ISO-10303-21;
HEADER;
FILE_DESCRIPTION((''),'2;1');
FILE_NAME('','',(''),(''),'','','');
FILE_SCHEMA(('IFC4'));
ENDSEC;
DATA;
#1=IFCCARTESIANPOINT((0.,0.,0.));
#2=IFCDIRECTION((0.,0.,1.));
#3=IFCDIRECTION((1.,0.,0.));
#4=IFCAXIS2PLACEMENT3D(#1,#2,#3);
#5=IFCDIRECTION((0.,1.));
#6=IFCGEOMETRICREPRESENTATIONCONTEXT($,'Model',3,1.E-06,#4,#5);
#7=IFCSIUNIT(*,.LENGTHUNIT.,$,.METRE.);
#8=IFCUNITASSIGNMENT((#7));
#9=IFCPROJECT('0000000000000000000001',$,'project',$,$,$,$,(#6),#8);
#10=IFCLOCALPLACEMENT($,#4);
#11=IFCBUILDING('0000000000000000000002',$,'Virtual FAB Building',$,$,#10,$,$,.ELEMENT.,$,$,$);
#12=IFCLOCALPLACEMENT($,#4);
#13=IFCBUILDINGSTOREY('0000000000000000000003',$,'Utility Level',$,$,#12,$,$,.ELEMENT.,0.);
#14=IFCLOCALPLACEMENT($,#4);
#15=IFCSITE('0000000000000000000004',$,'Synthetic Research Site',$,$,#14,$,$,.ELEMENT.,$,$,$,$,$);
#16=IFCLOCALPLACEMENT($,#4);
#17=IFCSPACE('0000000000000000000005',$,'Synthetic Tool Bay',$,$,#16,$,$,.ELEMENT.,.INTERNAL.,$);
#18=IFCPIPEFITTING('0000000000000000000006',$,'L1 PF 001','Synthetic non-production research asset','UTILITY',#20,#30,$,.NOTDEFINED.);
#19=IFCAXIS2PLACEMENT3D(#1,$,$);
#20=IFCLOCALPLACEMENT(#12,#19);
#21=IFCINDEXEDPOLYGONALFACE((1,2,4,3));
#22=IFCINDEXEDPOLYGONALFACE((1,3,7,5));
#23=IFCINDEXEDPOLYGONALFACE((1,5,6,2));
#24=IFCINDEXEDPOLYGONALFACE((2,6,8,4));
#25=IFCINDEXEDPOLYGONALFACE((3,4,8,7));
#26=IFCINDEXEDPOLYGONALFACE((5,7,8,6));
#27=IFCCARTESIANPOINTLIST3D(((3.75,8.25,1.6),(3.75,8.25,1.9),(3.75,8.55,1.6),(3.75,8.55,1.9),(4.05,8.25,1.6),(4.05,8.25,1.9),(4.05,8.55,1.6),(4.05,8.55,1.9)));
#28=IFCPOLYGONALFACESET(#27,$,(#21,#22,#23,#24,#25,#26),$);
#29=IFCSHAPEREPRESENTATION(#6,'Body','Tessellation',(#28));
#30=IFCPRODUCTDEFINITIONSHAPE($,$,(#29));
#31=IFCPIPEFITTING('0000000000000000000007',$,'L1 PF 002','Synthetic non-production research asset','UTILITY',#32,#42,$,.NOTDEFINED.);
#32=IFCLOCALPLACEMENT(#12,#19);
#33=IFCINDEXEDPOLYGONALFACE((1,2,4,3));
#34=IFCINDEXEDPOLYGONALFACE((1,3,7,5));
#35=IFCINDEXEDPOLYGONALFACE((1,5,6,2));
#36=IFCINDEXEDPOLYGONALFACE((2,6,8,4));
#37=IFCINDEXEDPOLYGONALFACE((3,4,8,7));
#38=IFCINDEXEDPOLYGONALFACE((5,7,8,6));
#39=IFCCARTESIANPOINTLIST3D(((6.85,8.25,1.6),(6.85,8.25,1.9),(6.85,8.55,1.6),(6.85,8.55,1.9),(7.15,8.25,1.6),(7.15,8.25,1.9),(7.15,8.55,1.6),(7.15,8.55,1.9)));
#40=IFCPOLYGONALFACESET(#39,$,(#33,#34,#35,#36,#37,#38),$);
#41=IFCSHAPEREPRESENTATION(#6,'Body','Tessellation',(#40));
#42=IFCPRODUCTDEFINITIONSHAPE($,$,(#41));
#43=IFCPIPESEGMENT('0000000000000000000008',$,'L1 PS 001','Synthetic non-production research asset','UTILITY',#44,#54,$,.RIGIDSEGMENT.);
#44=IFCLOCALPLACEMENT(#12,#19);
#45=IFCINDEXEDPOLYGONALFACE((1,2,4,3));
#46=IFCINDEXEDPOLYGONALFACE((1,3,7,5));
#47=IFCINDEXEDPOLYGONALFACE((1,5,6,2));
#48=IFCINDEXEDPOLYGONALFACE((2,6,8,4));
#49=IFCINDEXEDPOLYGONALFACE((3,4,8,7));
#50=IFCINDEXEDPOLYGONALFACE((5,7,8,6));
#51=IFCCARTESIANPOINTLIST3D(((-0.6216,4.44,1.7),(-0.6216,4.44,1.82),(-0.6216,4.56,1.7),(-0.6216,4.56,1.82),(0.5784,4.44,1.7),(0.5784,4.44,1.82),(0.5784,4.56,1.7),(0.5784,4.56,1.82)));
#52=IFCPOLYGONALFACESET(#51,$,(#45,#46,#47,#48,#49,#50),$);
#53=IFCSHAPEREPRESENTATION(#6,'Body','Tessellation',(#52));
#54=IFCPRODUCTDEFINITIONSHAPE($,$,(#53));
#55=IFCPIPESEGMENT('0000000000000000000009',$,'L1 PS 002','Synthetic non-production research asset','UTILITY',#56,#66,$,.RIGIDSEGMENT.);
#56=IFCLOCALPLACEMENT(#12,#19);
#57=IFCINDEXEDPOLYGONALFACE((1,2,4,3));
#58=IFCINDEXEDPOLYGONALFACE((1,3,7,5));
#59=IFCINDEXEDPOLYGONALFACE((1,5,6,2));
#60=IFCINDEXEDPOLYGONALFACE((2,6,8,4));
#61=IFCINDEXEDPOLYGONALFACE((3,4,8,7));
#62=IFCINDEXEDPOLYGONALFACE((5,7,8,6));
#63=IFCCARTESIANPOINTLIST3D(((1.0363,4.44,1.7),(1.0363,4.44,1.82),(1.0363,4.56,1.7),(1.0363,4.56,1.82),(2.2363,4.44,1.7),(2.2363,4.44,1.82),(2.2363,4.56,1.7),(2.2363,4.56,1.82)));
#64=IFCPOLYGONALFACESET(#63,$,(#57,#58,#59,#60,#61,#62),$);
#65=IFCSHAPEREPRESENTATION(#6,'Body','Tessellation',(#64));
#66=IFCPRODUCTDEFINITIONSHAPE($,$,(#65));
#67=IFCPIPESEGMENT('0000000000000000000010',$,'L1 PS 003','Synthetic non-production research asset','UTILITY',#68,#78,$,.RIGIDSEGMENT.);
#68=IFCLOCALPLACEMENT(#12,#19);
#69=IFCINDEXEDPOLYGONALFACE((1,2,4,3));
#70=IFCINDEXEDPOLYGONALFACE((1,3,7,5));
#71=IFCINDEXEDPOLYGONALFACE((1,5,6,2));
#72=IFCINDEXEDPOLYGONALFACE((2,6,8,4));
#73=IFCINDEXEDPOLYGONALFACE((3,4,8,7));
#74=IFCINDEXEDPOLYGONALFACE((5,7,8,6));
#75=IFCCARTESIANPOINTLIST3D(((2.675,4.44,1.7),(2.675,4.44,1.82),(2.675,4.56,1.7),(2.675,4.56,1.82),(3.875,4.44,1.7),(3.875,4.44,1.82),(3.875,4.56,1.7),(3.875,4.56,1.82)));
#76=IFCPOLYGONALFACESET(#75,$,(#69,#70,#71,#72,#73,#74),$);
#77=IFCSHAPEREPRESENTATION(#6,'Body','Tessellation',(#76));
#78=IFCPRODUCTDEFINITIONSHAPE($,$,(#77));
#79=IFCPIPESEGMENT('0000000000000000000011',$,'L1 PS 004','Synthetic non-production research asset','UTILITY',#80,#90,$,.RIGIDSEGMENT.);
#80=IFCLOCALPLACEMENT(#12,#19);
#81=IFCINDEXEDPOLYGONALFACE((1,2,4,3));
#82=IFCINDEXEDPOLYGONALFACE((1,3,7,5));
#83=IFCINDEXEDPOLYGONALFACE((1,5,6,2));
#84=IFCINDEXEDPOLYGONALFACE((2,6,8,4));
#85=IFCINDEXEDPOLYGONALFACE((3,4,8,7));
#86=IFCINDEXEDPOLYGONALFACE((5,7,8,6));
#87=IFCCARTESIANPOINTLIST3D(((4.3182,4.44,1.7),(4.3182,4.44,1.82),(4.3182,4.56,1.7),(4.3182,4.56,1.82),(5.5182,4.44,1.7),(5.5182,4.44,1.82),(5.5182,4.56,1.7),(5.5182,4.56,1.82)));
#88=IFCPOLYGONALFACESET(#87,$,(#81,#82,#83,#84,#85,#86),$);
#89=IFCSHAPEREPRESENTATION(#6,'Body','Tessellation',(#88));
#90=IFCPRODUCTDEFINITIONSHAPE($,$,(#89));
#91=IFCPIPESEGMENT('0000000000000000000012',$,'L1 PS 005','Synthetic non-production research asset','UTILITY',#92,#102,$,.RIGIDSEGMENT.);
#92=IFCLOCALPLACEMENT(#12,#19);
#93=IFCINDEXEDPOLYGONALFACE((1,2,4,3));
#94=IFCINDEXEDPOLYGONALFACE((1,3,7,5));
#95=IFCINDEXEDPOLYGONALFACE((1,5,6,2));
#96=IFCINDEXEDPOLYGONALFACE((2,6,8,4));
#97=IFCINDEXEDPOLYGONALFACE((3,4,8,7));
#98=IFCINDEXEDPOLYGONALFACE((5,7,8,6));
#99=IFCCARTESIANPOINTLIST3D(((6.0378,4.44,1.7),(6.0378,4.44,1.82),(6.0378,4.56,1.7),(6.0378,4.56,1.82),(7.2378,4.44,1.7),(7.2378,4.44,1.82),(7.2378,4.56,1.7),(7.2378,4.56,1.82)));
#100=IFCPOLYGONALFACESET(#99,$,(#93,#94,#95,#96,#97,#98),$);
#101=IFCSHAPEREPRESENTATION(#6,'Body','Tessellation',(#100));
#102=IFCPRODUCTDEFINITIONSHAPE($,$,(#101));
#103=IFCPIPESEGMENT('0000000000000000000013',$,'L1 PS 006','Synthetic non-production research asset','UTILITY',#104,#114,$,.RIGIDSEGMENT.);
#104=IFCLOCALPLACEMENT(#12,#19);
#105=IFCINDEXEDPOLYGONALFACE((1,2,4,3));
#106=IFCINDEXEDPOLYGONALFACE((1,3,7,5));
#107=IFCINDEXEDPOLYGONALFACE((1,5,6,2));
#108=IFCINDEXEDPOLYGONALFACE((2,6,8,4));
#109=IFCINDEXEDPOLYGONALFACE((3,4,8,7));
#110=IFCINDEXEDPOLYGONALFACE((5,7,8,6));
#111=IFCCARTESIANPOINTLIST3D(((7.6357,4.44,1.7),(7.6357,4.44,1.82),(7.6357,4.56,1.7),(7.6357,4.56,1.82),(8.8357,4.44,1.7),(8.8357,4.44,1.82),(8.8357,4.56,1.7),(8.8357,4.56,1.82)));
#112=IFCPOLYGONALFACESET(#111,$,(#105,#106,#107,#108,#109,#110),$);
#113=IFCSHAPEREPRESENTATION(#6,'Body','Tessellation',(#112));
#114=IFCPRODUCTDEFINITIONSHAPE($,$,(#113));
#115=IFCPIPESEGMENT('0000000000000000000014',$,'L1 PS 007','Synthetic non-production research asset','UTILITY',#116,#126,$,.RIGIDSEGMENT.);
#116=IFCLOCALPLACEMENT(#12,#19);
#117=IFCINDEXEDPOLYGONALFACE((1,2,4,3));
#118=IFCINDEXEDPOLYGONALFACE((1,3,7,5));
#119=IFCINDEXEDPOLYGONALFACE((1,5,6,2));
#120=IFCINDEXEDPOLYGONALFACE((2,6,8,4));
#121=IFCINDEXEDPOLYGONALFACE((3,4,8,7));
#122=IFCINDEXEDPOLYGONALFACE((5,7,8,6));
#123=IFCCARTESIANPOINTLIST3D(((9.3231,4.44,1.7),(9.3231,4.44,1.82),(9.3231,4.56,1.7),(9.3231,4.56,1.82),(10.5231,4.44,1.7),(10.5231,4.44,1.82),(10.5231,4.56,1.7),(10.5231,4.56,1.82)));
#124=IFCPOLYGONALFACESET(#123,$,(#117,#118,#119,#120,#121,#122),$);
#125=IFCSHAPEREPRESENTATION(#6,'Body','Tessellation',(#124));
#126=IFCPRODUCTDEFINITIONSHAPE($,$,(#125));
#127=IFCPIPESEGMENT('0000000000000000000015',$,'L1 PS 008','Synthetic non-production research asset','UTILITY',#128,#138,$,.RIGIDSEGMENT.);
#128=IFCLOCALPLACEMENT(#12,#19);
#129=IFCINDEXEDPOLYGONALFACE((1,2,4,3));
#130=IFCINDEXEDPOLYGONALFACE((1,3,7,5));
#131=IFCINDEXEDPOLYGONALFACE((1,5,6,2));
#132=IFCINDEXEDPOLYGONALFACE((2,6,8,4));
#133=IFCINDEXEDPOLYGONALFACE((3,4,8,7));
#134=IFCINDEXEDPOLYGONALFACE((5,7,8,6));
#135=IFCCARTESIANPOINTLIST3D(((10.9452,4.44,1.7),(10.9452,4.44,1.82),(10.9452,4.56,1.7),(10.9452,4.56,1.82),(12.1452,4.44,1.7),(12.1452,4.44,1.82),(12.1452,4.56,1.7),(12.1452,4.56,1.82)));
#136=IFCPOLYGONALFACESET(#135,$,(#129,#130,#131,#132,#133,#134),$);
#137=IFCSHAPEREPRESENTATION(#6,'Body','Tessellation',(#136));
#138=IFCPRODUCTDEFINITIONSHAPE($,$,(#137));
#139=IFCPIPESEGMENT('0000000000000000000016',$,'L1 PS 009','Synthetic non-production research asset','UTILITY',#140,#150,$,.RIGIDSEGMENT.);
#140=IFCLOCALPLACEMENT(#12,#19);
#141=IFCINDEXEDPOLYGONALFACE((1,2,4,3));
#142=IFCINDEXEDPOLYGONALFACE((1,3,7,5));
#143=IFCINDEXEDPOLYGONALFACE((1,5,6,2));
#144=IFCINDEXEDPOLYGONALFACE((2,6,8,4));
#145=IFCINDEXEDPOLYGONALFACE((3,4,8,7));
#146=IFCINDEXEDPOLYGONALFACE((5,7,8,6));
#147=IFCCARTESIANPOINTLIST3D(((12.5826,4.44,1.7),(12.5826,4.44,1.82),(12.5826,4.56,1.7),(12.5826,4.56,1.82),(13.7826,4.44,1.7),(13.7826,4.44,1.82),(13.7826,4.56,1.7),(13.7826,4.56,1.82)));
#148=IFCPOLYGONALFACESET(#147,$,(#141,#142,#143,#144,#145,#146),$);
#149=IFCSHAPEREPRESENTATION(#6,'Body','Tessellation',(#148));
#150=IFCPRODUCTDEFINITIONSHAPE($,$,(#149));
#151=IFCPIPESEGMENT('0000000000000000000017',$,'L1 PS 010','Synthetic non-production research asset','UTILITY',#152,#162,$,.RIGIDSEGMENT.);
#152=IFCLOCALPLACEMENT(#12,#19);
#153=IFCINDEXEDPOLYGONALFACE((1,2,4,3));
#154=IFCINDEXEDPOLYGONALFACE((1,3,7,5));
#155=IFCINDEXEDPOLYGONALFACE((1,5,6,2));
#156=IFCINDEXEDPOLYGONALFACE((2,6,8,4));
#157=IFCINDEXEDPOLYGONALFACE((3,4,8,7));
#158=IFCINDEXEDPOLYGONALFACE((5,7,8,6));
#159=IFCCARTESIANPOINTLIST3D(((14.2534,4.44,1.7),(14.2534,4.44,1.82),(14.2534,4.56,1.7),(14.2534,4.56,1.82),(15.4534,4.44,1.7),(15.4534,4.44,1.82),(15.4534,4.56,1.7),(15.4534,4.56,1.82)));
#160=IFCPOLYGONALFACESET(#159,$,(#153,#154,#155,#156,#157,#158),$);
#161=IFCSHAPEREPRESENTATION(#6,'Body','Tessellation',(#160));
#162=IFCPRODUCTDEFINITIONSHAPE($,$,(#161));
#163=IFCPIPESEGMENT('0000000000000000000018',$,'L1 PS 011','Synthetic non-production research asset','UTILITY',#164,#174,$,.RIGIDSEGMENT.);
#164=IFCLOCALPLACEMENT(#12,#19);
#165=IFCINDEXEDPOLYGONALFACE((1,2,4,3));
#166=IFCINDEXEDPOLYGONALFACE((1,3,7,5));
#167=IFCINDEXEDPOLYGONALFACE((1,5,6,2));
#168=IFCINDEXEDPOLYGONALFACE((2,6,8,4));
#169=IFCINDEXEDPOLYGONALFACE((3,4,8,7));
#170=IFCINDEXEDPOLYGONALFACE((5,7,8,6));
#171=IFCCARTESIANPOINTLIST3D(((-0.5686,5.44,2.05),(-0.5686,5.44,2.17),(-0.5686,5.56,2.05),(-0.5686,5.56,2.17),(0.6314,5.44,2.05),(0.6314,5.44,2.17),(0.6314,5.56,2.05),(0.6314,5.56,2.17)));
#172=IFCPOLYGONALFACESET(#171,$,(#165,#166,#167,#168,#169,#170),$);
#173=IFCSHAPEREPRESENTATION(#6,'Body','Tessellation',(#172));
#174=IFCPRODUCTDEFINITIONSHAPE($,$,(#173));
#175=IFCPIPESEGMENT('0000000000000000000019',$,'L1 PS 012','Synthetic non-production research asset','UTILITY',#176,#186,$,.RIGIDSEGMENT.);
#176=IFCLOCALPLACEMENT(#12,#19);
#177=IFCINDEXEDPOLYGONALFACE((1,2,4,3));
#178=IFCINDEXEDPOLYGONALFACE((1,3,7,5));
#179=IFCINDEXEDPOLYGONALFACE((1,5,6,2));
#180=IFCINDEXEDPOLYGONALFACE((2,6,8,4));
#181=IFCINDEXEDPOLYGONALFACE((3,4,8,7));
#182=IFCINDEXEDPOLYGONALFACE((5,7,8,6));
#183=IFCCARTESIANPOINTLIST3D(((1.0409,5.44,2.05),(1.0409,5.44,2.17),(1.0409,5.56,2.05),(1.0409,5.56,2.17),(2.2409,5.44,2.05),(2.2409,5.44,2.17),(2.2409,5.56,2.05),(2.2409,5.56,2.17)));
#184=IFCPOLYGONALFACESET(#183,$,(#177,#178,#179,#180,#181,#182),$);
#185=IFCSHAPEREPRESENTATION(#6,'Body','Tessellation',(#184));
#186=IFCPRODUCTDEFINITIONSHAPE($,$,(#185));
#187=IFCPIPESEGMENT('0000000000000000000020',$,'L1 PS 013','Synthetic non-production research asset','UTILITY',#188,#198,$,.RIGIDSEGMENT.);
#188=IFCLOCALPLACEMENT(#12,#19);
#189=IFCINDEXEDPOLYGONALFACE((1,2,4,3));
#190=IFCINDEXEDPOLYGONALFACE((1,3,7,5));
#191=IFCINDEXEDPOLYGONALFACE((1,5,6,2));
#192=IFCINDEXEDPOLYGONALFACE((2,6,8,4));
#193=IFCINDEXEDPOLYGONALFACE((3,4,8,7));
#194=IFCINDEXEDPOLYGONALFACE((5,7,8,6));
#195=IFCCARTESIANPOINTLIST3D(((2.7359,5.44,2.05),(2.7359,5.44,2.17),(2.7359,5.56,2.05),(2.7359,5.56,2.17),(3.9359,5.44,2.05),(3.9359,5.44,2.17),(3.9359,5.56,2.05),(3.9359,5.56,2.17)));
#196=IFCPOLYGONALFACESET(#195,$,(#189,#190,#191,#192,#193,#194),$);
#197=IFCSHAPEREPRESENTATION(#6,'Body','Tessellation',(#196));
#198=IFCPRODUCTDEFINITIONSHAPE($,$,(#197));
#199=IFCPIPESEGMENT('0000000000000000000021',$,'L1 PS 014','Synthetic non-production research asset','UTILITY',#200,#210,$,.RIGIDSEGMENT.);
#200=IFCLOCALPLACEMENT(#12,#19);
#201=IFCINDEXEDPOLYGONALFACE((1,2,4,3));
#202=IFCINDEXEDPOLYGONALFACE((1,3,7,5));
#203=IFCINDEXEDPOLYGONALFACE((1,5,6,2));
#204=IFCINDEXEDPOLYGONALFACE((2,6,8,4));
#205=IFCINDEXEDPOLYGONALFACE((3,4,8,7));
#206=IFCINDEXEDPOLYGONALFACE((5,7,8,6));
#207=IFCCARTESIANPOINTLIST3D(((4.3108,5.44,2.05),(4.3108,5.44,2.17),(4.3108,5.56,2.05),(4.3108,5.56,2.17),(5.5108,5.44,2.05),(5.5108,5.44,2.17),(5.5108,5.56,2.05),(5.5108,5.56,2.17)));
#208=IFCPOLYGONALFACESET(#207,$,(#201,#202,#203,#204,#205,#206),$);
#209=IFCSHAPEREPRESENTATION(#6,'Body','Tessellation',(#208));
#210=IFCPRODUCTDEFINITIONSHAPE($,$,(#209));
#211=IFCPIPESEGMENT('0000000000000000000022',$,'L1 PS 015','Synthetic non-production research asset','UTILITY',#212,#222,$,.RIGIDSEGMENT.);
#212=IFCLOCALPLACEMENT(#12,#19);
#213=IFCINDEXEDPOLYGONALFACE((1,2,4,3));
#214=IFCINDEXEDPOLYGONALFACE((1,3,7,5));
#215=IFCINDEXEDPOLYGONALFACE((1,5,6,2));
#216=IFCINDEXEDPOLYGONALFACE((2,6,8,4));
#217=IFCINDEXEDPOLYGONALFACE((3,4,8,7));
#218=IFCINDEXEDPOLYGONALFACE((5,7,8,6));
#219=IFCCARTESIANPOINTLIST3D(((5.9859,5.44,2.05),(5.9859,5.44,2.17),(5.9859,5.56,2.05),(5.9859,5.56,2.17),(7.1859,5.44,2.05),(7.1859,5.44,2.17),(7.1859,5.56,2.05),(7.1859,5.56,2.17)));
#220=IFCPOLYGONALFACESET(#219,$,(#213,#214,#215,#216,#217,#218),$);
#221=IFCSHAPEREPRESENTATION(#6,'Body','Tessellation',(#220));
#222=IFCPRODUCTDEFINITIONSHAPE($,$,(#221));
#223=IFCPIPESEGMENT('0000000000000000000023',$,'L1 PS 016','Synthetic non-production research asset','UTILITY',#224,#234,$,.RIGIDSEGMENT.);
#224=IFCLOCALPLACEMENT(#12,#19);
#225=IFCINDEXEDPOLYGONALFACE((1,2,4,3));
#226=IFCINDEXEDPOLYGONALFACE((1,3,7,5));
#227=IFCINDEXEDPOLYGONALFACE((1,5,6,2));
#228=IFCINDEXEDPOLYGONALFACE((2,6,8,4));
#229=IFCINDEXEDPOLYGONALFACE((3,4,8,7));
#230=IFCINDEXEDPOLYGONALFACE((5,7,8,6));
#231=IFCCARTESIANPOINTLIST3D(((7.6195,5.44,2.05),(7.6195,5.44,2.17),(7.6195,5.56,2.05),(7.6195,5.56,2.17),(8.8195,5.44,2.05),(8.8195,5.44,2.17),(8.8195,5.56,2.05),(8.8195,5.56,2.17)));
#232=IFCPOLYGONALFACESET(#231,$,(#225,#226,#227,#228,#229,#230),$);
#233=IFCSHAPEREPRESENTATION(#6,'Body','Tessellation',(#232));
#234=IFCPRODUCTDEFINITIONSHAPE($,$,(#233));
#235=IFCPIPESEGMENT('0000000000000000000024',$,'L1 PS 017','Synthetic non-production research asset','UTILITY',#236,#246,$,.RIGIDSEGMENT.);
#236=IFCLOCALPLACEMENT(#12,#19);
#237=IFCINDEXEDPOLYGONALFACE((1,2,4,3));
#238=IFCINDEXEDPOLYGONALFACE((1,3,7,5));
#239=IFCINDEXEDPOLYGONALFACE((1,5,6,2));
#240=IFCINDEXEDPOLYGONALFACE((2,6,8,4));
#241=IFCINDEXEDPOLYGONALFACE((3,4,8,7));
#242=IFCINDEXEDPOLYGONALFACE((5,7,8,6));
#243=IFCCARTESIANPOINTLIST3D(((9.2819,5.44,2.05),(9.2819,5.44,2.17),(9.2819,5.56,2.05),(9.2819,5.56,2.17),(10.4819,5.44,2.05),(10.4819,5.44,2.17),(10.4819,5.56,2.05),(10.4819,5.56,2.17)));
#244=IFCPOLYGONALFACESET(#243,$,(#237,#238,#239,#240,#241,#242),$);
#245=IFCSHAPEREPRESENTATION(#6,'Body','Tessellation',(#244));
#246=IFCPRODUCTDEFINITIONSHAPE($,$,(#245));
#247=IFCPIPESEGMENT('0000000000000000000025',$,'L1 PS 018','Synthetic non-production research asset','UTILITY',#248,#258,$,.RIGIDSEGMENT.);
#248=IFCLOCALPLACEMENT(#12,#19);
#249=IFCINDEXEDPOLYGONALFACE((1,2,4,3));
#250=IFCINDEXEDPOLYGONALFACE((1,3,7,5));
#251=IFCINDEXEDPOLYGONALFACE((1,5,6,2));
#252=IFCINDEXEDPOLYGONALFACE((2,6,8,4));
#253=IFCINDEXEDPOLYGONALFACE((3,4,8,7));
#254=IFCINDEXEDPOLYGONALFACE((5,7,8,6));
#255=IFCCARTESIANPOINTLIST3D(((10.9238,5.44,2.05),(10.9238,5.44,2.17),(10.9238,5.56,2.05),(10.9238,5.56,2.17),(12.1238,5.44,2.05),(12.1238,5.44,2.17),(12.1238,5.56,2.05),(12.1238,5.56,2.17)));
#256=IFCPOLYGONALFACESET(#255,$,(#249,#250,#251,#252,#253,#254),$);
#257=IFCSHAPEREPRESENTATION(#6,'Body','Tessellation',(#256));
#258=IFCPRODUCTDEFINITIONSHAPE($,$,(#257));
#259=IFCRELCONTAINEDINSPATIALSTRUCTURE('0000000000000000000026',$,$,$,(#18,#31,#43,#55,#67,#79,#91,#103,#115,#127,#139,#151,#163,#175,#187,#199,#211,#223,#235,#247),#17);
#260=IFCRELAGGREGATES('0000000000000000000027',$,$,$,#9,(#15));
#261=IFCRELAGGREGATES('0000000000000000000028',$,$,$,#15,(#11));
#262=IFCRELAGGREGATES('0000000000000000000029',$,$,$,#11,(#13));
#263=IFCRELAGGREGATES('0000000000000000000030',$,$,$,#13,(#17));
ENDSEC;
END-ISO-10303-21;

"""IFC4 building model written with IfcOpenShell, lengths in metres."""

from ifc_helpers import new_model, si_unit, direction, frame, origin_with_axes, origin_2d_with_axis, place, context, project, spatial, rectangle, extrude, element, save


model = new_model("IFC4")

# Units and contexts
model_context = context("Model", 3, precision=1e-06, world=origin_with_axes(), true_north=direction((0.0, 1.0)))
ifc_project = project(units=[si_unit("LENGTHUNIT", "METRE")], contexts=[model_context])

# Site, building, storey, space
site_placement = place(None, origin_with_axes())
site = spatial("IfcSite", under=ifc_project, at=site_placement, Name="Synthetic Research Site", CompositionType="ELEMENT")
building_placement = place(None, origin_with_axes())
building = spatial("IfcBuilding", under=site, at=building_placement, Name="Virtual FAB Building", CompositionType="ELEMENT")
storey_placement = place(None, origin_with_axes())
storey = spatial("IfcBuildingStorey", under=building, at=storey_placement, Name="Utility Level", CompositionType="ELEMENT", Elevation=0.0)
space_placement = place(None, origin_with_axes())
space = spatial("IfcSpace", under=storey, at=space_placement, Name="Synthetic Tool Bay", CompositionType="ELEMENT", PredefinedType="INTERNAL")

# Pipe fittings
for number, where, z_axis, x_axis, name in (
    (1, (3.9, 8.4, 1.6), (0.0, 0.0, 1.0), (1.0, 0.0, 0.0), "L1 PF 001"),
    (2, (7.0, 8.4, 1.6), (0.0, 0.0, 1.0), (1.0, 0.0, 0.0), "L1 PF 002"),
):
    element("IfcPipeFitting", number, at=place(None, frame(where, z_axis=z_axis, x_axis=x_axis)), inside=space, Name=name, Description="Synthetic non-production research asset", ObjectType="UTILITY", PredefinedType="NOTDEFINED", context=model_context, shape_type="SweptSolid", body=[
        extrude(rectangle(XDim=0.3, YDim=0.3, at=origin_2d_with_axis()), origin_with_axes(), (0.0, 0.0, 1.0), 0.3),
    ])

# Pipe segments
for number, where, z_axis, x_axis, name in (
    (3, (-0.0216, 4.5, 1.7), (0.0, 0.0, 1.0), (1.0, 0.0, 0.0), "L1 PS 001"),
    (4, (1.6363, 4.5, 1.7), (0.0, 0.0, 1.0), (1.0, 0.0, 0.0), "L1 PS 002"),
    (5, (3.275, 4.5, 1.7), (0.0, 0.0, 1.0), (1.0, 0.0, 0.0), "L1 PS 003"),
    (6, (4.9182, 4.5, 1.7), (0.0, 0.0, 1.0), (1.0, 0.0, 0.0), "L1 PS 004"),
    (7, (6.6378, 4.5, 1.7), (0.0, 0.0, 1.0), (1.0, 0.0, 0.0), "L1 PS 005"),
    (8, (8.2357, 4.5, 1.7), (0.0, 0.0, 1.0), (1.0, 0.0, 0.0), "L1 PS 006"),
    (9, (9.9231, 4.5, 1.7), (0.0, 0.0, 1.0), (1.0, 0.0, 0.0), "L1 PS 007"),
    (10, (11.5452, 4.5, 1.7), (0.0, 0.0, 1.0), (1.0, 0.0, 0.0), "L1 PS 008"),
    (11, (13.1826, 4.5, 1.7), (0.0, 0.0, 1.0), (1.0, 0.0, 0.0), "L1 PS 009"),
    (12, (14.8534, 4.5, 1.7), (0.0, 0.0, 1.0), (1.0, 0.0, 0.0), "L1 PS 010"),
    (13, (0.0314, 5.5, 2.05), (0.0, 0.0, 1.0), (1.0, 0.0, 0.0), "L1 PS 011"),
    (14, (1.6409, 5.5, 2.05), (0.0, 0.0, 1.0), (1.0, 0.0, 0.0), "L1 PS 012"),
    (15, (3.3359, 5.5, 2.05), (0.0, 0.0, 1.0), (1.0, 0.0, 0.0), "L1 PS 013"),
    (16, (4.9108, 5.5, 2.05), (0.0, 0.0, 1.0), (1.0, 0.0, 0.0), "L1 PS 014"),
    (17, (6.5859, 5.5, 2.05), (0.0, 0.0, 1.0), (1.0, 0.0, 0.0), "L1 PS 015"),
    (18, (8.2195, 5.5, 2.05), (0.0, 0.0, 1.0), (1.0, 0.0, 0.0), "L1 PS 016"),
    (19, (9.8819, 5.5, 2.05), (0.0, 0.0, 1.0), (1.0, 0.0, 0.0), "L1 PS 017"),
    (20, (11.5238, 5.5, 2.05), (0.0, 0.0, 1.0), (1.0, 0.0, 0.0), "L1 PS 018"),
):
    element("IfcPipeSegment", number, at=place(None, frame(where, z_axis=z_axis, x_axis=x_axis)), inside=space, Name=name, Description="Synthetic non-production research asset", ObjectType="UTILITY", PredefinedType="RIGIDSEGMENT", context=model_context, shape_type="SweptSolid", body=[
        extrude(rectangle(XDim=1.2, YDim=0.12, at=origin_2d_with_axis()), origin_with_axes(), (0.0, 0.0, 1.0), 0.12),
    ])

save(model, "model.ifc")
